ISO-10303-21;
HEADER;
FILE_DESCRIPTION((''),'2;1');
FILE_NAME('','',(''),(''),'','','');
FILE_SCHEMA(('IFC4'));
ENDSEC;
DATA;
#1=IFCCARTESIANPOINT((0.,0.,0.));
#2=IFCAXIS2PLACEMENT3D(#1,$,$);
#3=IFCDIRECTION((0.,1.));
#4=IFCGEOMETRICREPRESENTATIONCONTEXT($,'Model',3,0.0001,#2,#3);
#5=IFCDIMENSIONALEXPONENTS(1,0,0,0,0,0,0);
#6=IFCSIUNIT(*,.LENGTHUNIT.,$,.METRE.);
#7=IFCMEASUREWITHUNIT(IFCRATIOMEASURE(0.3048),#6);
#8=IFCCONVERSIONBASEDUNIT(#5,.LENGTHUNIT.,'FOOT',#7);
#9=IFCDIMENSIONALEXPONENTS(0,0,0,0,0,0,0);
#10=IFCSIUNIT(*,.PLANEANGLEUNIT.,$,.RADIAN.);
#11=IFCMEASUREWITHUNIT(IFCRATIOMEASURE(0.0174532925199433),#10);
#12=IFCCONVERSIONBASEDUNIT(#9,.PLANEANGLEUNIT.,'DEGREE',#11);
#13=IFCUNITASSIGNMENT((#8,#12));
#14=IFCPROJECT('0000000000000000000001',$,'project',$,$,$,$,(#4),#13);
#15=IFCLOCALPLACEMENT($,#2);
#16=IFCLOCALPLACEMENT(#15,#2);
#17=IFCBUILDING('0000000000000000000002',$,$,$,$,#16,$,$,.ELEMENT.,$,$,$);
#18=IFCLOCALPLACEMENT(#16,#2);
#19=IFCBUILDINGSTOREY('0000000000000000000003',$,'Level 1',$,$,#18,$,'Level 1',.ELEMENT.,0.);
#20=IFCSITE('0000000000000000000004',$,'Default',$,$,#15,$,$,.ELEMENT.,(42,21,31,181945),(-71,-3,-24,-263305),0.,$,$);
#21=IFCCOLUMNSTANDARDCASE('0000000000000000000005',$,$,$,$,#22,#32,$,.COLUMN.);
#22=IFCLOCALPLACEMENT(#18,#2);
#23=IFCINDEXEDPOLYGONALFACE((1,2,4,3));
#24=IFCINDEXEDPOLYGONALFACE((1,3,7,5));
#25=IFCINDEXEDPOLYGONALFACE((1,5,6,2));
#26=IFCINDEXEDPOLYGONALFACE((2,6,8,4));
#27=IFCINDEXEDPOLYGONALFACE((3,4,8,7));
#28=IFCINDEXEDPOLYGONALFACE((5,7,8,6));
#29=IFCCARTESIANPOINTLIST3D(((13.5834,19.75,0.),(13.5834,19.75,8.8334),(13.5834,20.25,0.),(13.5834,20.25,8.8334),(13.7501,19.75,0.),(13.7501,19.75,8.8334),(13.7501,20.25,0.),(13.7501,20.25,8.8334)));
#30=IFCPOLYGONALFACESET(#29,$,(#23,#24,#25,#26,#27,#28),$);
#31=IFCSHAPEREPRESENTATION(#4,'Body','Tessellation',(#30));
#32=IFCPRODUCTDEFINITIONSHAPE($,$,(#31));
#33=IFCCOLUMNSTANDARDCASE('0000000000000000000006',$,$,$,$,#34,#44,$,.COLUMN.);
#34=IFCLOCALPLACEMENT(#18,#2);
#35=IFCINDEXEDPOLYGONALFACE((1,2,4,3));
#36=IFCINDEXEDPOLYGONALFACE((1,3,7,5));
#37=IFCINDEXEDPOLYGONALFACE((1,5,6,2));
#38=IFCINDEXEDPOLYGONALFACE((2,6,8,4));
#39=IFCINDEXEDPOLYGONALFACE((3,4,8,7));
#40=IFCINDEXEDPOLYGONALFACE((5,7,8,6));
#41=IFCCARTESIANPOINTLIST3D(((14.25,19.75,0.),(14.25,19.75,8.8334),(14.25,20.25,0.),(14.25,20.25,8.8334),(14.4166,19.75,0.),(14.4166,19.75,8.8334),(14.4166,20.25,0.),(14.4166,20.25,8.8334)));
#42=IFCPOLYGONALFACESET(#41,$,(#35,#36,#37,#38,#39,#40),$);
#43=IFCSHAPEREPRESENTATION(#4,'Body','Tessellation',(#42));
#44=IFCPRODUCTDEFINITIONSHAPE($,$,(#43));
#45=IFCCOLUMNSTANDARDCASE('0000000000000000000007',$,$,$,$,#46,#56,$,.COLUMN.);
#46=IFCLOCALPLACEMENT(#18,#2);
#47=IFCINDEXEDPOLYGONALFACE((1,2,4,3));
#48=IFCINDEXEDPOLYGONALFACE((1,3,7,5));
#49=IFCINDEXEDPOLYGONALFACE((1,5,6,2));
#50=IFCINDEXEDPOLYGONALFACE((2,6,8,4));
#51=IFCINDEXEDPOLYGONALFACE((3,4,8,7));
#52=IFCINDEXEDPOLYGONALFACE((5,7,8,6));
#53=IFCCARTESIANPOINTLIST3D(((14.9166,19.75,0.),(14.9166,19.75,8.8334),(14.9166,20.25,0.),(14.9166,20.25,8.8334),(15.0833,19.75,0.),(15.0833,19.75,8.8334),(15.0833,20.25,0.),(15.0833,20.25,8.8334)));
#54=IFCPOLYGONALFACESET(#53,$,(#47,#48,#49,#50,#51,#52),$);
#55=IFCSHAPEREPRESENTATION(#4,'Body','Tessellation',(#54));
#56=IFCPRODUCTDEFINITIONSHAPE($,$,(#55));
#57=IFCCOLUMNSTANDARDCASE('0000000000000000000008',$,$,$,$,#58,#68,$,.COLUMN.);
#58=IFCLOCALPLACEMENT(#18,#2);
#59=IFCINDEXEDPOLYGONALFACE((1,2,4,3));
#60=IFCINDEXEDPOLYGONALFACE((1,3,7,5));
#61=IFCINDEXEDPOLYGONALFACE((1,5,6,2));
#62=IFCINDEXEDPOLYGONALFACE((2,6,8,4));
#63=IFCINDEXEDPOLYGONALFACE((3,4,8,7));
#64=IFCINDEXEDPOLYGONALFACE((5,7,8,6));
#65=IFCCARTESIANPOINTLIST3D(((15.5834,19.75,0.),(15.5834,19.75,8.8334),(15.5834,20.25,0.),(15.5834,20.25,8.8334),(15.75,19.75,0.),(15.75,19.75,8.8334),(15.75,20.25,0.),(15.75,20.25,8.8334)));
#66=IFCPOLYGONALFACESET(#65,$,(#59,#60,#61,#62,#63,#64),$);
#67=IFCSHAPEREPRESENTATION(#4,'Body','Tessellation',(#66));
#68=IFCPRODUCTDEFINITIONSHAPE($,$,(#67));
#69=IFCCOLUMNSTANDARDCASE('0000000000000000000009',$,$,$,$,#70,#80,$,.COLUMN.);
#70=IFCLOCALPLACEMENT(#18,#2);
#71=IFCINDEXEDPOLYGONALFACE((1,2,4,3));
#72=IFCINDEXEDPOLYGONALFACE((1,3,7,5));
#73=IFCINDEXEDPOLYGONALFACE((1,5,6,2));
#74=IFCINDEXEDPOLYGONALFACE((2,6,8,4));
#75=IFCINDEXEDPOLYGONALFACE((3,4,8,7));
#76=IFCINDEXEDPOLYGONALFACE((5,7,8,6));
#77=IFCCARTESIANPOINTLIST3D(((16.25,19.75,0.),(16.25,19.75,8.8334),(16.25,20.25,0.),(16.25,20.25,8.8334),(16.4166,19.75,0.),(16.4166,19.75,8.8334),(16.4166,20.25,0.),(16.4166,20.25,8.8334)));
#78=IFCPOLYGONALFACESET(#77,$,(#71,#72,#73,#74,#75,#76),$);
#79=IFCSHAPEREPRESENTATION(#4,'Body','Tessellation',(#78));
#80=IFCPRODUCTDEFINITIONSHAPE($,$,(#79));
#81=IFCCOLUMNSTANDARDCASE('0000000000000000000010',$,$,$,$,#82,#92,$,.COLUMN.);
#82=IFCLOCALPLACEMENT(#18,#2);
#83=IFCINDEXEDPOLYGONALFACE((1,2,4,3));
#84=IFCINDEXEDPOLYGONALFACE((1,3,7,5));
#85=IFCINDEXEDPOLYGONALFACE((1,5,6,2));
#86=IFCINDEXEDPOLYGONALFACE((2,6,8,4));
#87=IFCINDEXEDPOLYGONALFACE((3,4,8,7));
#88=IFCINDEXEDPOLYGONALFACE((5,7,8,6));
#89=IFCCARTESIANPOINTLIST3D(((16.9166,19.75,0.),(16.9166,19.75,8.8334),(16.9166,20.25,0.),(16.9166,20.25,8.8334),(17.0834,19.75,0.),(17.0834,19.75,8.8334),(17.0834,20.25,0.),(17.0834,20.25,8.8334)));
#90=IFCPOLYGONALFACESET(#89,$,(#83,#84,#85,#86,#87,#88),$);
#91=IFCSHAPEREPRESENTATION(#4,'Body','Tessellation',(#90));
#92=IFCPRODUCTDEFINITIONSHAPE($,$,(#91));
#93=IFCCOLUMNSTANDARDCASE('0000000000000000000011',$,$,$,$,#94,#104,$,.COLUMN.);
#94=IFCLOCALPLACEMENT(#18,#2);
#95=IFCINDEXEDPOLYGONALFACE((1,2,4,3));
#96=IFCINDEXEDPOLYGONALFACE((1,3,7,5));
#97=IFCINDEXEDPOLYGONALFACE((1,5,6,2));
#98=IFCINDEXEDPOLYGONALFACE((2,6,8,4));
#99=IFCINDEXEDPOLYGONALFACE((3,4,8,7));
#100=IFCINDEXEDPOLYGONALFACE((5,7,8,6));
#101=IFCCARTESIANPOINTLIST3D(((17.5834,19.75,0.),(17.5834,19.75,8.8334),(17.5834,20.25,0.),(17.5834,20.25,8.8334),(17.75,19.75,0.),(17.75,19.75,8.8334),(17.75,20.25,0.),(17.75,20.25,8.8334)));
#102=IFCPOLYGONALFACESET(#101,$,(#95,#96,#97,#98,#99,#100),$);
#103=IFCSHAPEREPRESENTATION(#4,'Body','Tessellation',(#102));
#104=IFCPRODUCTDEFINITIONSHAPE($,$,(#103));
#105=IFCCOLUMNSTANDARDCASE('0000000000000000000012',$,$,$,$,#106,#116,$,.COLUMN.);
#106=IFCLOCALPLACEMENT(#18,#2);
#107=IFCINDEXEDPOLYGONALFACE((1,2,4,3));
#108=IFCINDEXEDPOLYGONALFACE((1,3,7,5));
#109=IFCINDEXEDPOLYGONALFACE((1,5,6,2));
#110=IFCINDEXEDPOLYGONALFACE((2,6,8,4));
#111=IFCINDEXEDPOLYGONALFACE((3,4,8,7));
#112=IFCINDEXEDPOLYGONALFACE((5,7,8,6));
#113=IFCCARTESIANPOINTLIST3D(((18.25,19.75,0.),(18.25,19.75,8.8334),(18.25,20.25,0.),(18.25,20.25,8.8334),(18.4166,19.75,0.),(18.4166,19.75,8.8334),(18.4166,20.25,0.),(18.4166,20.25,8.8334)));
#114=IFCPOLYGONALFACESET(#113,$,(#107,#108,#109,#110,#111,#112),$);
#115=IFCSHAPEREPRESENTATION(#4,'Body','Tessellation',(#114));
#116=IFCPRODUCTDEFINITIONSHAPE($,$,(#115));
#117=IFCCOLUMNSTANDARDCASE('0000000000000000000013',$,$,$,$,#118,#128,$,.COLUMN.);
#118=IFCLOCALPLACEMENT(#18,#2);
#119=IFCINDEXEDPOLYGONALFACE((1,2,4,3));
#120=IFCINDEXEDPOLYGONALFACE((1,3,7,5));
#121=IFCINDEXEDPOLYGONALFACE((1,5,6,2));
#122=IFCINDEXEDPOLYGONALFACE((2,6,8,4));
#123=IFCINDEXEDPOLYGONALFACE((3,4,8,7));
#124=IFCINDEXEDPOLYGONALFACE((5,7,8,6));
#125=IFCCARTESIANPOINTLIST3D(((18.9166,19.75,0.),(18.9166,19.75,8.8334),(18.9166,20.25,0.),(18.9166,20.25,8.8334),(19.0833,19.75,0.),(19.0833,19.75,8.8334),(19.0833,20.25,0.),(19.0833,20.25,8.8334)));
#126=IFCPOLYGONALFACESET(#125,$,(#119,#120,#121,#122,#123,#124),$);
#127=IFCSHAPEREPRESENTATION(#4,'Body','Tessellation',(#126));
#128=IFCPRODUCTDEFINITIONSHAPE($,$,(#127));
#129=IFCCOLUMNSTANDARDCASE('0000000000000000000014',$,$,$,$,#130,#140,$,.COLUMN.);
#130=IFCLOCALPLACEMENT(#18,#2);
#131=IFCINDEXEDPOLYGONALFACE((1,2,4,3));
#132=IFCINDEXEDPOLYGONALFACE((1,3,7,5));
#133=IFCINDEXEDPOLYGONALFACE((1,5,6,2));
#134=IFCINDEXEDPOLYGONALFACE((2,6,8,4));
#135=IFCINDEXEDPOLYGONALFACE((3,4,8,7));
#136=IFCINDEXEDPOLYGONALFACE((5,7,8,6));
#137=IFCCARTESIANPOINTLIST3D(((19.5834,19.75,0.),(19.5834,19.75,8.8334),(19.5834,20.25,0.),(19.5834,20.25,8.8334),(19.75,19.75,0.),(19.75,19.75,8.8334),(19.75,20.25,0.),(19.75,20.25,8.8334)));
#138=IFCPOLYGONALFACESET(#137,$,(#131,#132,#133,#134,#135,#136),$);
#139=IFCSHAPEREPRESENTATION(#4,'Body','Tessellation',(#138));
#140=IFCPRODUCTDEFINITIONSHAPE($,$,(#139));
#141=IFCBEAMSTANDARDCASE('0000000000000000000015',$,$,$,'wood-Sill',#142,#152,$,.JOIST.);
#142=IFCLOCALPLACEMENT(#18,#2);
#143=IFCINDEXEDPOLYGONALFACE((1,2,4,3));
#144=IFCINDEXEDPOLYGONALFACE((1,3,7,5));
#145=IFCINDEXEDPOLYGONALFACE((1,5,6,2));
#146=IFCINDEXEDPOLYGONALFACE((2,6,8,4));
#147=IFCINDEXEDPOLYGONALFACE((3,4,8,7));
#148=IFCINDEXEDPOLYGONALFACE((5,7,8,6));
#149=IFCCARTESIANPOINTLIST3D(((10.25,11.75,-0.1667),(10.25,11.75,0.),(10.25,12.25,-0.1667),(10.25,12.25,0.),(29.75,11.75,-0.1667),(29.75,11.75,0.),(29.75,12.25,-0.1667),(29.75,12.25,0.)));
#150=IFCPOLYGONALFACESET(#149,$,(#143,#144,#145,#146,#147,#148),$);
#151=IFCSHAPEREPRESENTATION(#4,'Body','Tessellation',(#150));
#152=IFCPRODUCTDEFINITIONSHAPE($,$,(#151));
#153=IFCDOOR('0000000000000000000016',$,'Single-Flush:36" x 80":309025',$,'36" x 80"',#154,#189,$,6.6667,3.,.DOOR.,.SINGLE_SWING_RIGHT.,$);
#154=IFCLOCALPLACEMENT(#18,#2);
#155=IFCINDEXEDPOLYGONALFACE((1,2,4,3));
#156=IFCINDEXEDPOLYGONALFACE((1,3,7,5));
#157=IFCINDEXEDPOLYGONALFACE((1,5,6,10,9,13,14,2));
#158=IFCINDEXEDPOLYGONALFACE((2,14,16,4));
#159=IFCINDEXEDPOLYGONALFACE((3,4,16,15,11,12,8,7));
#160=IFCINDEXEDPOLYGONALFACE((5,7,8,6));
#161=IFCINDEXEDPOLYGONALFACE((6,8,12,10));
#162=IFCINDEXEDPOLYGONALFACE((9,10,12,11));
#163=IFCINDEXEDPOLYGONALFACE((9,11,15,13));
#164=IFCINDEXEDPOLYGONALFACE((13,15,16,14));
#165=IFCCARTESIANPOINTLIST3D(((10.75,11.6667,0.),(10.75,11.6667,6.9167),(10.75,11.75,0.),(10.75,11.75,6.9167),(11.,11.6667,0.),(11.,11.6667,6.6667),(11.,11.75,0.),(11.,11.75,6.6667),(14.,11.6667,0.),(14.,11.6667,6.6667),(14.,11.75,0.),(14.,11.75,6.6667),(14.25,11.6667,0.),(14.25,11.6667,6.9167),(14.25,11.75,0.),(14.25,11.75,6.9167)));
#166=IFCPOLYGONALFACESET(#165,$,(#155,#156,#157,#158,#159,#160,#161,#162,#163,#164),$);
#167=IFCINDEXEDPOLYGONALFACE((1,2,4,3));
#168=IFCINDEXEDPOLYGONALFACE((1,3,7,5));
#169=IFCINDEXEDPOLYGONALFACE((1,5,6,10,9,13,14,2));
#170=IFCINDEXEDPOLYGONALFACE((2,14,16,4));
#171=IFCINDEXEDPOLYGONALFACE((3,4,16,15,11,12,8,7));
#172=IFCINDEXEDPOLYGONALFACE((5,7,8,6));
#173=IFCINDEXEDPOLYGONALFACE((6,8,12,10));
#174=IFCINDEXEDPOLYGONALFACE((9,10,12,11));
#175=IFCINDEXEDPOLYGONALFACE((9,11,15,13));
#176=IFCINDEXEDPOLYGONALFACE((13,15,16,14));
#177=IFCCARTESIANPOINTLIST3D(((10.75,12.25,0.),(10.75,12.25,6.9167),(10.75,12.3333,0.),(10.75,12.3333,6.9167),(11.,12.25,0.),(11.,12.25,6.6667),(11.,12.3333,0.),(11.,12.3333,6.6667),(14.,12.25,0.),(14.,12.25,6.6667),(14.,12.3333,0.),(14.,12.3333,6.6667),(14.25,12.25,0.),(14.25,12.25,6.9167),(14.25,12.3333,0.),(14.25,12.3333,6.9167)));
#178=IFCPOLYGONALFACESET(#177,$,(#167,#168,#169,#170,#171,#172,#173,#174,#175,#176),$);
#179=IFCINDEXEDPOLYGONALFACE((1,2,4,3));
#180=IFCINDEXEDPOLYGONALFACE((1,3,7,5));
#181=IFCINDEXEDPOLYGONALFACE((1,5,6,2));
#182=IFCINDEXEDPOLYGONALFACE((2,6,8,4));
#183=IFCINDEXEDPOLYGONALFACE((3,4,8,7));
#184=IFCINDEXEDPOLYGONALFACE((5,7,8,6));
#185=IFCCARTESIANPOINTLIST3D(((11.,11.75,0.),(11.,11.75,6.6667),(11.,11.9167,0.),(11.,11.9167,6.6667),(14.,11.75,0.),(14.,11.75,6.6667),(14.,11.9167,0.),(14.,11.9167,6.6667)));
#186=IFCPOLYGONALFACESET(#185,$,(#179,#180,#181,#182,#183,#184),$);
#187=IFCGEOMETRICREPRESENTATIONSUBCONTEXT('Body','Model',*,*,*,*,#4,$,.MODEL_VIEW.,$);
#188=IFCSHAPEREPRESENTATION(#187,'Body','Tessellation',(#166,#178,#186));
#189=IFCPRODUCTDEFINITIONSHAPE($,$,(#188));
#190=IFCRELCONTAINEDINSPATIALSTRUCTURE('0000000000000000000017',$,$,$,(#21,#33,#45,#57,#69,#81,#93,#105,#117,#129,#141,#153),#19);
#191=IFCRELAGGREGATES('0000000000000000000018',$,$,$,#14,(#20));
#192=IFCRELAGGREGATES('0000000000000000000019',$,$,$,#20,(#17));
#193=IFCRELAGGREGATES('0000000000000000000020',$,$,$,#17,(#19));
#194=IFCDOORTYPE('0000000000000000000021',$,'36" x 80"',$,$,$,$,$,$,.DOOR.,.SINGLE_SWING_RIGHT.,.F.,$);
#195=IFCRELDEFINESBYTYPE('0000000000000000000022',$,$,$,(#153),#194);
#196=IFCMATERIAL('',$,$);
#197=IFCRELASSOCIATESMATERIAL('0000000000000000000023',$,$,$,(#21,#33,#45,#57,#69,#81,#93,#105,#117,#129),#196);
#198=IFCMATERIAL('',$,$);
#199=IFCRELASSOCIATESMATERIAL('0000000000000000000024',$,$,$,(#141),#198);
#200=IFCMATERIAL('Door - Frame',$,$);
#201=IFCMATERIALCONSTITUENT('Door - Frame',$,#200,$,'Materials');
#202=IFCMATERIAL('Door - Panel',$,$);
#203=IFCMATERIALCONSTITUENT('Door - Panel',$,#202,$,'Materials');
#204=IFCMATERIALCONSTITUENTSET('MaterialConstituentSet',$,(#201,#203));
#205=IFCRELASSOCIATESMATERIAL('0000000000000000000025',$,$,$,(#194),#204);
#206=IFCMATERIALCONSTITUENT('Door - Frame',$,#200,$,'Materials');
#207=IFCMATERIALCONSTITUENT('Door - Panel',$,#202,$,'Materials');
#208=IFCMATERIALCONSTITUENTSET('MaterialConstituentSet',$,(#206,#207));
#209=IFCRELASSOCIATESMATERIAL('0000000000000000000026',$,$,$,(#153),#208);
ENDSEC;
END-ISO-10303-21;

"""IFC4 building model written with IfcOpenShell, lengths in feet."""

from ifc_helpers import new_model, entity, si_unit, converted_unit, direction, frame, origin, origin_2d_with_axis, place, context, subcontext, project, spatial, polyline, rectangle, outline, extrude, source, transform, mapped, material, constituent, constituent_set, type_object, type_shapes, element, save


model = new_model("IFC4")

# Units and contexts
model_context = context("Model", 3, precision=0.0001, world=origin(), true_north=direction((0.0, 1.0)))
body_context = subcontext(model_context, "Body", "Model", "MODEL_VIEW")
ifc_project = project(units=[converted_unit("LENGTHUNIT", "FOOT", entity("IfcRatioMeasure", 0.3048), si_unit("LENGTHUNIT", "METRE"), dimensions=[1, 0, 0, 0, 0, 0, 0]), converted_unit("PLANEANGLEUNIT", "DEGREE", entity("IfcRatioMeasure", 0.0174532925199433), si_unit("PLANEANGLEUNIT", "RADIAN"), dimensions=[0, 0, 0, 0, 0, 0, 0])], contexts=[model_context])

# Site, building, storey
site_placement = place(None, origin())
site = spatial("IfcSite", under=ifc_project, at=site_placement, Name="Default", CompositionType="ELEMENT", RefLatitude=(42, 21, 31, 181945), RefLongitude=(-71, -3, -24, -263305), RefElevation=0.0)
building_placement = place(site_placement, origin())
building = spatial("IfcBuilding", under=site, at=building_placement, CompositionType="ELEMENT")
storey_placement = place(building_placement, origin())
storey = spatial("IfcBuildingStorey", under=building, at=storey_placement, Name="Level 1", LongName="Level 1", CompositionType="ELEMENT", Elevation=0.0)

# Columns
ifc_material_1 = material(Name="")
placement_1 = place(storey_placement, frame((0.25, 20.0, 0.0)))
for number, where, z_axis, x_axis in (
    (1, (13.4167, 0.0, 0.0), (0.0, 0.0, 1.0), (1.0, 0.0, 0.0)),
    (2, (14.0833, 0.0, 0.0), (0.0, 0.0, 1.0), (1.0, 0.0, 0.0)),
    (3, (14.75, 0.0, 0.0), (0.0, 0.0, 1.0), (1.0, 0.0, 0.0)),
    (4, (15.4167, 0.0, 0.0), (0.0, 0.0, 1.0), (1.0, 0.0, 0.0)),
    (5, (16.0833, 0.0, 0.0), (0.0, 0.0, 1.0), (1.0, 0.0, 0.0)),
    (6, (16.75, 0.0, 0.0), (0.0, 0.0, 1.0), (1.0, 0.0, 0.0)),
    (7, (17.4167, 0.0, 0.0), (0.0, 0.0, 1.0), (1.0, 0.0, 0.0)),
    (8, (18.0833, 0.0, 0.0), (0.0, 0.0, 1.0), (1.0, 0.0, 0.0)),
    (9, (18.75, 0.0, 0.0), (0.0, 0.0, 1.0), (1.0, 0.0, 0.0)),
    (10, (19.4167, 0.0, 0.0), (0.0, 0.0, 1.0), (1.0, 0.0, 0.0)),
):
    element("IfcColumnStandardCase", number, at=place(placement_1, frame(where, z_axis=z_axis, x_axis=x_axis)), inside=storey, material=ifc_material_1, PredefinedType="COLUMN", context=model_context, shape_type="SweptSolid", body=[
        extrude(rectangle(XDim=0.1667, YDim=0.5), origin(), (0.0, 0.0, 1.0), 8.8334),
    ])
placement_2 = place(storey_placement, frame((10.25, 12.0, 0.0)))

# Beam
ifc_material_2 = material(Name="")
beam_placement = place(placement_2, frame((9.75, 0.0, -0.1667), z_axis=(0.0, 0.0, 1.0), x_axis=(1.0, 0.0, 0.0)))
element("IfcBeamStandardCase", 11, at=beam_placement, inside=storey, material=ifc_material_2, ObjectType="wood-Sill", PredefinedType="JOIST", context=model_context, shape_type="SweptSolid", body=[
    extrude(rectangle(XDim=19.5, YDim=0.5), origin(), (0.0, 0.0, 1.0), 0.1667),
])

# Door
ifc_material_3 = material(Name="Door - Frame")
ifc_constituent_1 = constituent(ifc_material_3, Name="Door - Frame", Category="Materials")
ifc_material_4 = material(Name="Door - Panel")
ifc_constituent_2 = constituent(ifc_material_4, Name="Door - Panel", Category="Materials")
ifc_constituent_set_1 = constituent_set(constituents=[ifc_constituent_1, ifc_constituent_2], Name="MaterialConstituentSet")
ifc_constituent_3 = constituent(ifc_material_3, Name="Door - Frame", Category="Materials")
ifc_constituent_4 = constituent(ifc_material_4, Name="Door - Panel", Category="Materials")
ifc_constituent_set_2 = constituent_set(constituents=[ifc_constituent_3, ifc_constituent_4], Name="MaterialConstituentSet")
door_type = type_object("IfcDoorType", Name="36\" x 80\"", OperationType="SINGLE_SWING_RIGHT", ParameterTakesPrecedence=False, PredefinedType="DOOR", material=ifc_constituent_set_2)
shared_shape = source(origin(), body_context, "Body", "SweptSolid", [
    extrude(outline(polyline([(-1.75, -3.5208), (1.75, -3.5208), (1.75, 3.3958), (1.5, 3.3958), (1.5, -3.2708), (-1.5, -3.2708), (-1.5, 3.3958), (-1.75, 3.3958), (-1.75, -3.5208)])), frame((1.5, 0.5, 3.3958), z_axis=(0.0, 1.0, 0.0), x_axis=(1.0, 0.0, 0.0)), (0.0, 0.0, 1.0), 0.0833),
    extrude(outline(polyline([(-3.5208, -1.75), (3.3958, -1.75), (3.3958, -1.5), (-3.2708, -1.5), (-3.2708, 1.5), (3.3958, 1.5), (3.3958, 1.75), (-3.5208, 1.75), (-3.5208, -1.75)])), frame((1.5, -0.0833, 3.3958), z_axis=(0.0, 1.0, 0.0), x_axis=(0.0, 0.0, -1.0)), (0.0, 0.0, 1.0), 0.0833),
    extrude(rectangle(XDim=0.1667, YDim=3.0, at=origin_2d_with_axis()), frame((1.5, 0.4167, 0.0), z_axis=(0.0, 0.0, 1.0), x_axis=(0.0, 1.0, 0.0)), (0.0, 0.0, 1.0), 6.6667),
])
type_shapes(door_type, [shared_shape])
placement_3 = place(placement_2, frame((3.75, 0.25, 0.0)))
door_placement = place(placement_3, frame((0.0, 0.0, 0.0), z_axis=(0.0, 0.0, 1.0), x_axis=(-1.0, 0.0, 0.0)))
element("IfcDoor", 12, at=door_placement, inside=storey, type_object=door_type, material=ifc_constituent_set_1, Name="Single-Flush:36\" x 80\":309025", ObjectType="36\" x 80\"", OperationType="SINGLE_SWING_RIGHT", OverallHeight=6.6667, OverallWidth=3.0, PredefinedType="DOOR", context=body_context, shape_type="MappedRepresentation", body=[
    mapped(shared_shape, transform((0.0, 0.0, 0.0), scale=1.0)),
])

save(model, "model.ifc")
